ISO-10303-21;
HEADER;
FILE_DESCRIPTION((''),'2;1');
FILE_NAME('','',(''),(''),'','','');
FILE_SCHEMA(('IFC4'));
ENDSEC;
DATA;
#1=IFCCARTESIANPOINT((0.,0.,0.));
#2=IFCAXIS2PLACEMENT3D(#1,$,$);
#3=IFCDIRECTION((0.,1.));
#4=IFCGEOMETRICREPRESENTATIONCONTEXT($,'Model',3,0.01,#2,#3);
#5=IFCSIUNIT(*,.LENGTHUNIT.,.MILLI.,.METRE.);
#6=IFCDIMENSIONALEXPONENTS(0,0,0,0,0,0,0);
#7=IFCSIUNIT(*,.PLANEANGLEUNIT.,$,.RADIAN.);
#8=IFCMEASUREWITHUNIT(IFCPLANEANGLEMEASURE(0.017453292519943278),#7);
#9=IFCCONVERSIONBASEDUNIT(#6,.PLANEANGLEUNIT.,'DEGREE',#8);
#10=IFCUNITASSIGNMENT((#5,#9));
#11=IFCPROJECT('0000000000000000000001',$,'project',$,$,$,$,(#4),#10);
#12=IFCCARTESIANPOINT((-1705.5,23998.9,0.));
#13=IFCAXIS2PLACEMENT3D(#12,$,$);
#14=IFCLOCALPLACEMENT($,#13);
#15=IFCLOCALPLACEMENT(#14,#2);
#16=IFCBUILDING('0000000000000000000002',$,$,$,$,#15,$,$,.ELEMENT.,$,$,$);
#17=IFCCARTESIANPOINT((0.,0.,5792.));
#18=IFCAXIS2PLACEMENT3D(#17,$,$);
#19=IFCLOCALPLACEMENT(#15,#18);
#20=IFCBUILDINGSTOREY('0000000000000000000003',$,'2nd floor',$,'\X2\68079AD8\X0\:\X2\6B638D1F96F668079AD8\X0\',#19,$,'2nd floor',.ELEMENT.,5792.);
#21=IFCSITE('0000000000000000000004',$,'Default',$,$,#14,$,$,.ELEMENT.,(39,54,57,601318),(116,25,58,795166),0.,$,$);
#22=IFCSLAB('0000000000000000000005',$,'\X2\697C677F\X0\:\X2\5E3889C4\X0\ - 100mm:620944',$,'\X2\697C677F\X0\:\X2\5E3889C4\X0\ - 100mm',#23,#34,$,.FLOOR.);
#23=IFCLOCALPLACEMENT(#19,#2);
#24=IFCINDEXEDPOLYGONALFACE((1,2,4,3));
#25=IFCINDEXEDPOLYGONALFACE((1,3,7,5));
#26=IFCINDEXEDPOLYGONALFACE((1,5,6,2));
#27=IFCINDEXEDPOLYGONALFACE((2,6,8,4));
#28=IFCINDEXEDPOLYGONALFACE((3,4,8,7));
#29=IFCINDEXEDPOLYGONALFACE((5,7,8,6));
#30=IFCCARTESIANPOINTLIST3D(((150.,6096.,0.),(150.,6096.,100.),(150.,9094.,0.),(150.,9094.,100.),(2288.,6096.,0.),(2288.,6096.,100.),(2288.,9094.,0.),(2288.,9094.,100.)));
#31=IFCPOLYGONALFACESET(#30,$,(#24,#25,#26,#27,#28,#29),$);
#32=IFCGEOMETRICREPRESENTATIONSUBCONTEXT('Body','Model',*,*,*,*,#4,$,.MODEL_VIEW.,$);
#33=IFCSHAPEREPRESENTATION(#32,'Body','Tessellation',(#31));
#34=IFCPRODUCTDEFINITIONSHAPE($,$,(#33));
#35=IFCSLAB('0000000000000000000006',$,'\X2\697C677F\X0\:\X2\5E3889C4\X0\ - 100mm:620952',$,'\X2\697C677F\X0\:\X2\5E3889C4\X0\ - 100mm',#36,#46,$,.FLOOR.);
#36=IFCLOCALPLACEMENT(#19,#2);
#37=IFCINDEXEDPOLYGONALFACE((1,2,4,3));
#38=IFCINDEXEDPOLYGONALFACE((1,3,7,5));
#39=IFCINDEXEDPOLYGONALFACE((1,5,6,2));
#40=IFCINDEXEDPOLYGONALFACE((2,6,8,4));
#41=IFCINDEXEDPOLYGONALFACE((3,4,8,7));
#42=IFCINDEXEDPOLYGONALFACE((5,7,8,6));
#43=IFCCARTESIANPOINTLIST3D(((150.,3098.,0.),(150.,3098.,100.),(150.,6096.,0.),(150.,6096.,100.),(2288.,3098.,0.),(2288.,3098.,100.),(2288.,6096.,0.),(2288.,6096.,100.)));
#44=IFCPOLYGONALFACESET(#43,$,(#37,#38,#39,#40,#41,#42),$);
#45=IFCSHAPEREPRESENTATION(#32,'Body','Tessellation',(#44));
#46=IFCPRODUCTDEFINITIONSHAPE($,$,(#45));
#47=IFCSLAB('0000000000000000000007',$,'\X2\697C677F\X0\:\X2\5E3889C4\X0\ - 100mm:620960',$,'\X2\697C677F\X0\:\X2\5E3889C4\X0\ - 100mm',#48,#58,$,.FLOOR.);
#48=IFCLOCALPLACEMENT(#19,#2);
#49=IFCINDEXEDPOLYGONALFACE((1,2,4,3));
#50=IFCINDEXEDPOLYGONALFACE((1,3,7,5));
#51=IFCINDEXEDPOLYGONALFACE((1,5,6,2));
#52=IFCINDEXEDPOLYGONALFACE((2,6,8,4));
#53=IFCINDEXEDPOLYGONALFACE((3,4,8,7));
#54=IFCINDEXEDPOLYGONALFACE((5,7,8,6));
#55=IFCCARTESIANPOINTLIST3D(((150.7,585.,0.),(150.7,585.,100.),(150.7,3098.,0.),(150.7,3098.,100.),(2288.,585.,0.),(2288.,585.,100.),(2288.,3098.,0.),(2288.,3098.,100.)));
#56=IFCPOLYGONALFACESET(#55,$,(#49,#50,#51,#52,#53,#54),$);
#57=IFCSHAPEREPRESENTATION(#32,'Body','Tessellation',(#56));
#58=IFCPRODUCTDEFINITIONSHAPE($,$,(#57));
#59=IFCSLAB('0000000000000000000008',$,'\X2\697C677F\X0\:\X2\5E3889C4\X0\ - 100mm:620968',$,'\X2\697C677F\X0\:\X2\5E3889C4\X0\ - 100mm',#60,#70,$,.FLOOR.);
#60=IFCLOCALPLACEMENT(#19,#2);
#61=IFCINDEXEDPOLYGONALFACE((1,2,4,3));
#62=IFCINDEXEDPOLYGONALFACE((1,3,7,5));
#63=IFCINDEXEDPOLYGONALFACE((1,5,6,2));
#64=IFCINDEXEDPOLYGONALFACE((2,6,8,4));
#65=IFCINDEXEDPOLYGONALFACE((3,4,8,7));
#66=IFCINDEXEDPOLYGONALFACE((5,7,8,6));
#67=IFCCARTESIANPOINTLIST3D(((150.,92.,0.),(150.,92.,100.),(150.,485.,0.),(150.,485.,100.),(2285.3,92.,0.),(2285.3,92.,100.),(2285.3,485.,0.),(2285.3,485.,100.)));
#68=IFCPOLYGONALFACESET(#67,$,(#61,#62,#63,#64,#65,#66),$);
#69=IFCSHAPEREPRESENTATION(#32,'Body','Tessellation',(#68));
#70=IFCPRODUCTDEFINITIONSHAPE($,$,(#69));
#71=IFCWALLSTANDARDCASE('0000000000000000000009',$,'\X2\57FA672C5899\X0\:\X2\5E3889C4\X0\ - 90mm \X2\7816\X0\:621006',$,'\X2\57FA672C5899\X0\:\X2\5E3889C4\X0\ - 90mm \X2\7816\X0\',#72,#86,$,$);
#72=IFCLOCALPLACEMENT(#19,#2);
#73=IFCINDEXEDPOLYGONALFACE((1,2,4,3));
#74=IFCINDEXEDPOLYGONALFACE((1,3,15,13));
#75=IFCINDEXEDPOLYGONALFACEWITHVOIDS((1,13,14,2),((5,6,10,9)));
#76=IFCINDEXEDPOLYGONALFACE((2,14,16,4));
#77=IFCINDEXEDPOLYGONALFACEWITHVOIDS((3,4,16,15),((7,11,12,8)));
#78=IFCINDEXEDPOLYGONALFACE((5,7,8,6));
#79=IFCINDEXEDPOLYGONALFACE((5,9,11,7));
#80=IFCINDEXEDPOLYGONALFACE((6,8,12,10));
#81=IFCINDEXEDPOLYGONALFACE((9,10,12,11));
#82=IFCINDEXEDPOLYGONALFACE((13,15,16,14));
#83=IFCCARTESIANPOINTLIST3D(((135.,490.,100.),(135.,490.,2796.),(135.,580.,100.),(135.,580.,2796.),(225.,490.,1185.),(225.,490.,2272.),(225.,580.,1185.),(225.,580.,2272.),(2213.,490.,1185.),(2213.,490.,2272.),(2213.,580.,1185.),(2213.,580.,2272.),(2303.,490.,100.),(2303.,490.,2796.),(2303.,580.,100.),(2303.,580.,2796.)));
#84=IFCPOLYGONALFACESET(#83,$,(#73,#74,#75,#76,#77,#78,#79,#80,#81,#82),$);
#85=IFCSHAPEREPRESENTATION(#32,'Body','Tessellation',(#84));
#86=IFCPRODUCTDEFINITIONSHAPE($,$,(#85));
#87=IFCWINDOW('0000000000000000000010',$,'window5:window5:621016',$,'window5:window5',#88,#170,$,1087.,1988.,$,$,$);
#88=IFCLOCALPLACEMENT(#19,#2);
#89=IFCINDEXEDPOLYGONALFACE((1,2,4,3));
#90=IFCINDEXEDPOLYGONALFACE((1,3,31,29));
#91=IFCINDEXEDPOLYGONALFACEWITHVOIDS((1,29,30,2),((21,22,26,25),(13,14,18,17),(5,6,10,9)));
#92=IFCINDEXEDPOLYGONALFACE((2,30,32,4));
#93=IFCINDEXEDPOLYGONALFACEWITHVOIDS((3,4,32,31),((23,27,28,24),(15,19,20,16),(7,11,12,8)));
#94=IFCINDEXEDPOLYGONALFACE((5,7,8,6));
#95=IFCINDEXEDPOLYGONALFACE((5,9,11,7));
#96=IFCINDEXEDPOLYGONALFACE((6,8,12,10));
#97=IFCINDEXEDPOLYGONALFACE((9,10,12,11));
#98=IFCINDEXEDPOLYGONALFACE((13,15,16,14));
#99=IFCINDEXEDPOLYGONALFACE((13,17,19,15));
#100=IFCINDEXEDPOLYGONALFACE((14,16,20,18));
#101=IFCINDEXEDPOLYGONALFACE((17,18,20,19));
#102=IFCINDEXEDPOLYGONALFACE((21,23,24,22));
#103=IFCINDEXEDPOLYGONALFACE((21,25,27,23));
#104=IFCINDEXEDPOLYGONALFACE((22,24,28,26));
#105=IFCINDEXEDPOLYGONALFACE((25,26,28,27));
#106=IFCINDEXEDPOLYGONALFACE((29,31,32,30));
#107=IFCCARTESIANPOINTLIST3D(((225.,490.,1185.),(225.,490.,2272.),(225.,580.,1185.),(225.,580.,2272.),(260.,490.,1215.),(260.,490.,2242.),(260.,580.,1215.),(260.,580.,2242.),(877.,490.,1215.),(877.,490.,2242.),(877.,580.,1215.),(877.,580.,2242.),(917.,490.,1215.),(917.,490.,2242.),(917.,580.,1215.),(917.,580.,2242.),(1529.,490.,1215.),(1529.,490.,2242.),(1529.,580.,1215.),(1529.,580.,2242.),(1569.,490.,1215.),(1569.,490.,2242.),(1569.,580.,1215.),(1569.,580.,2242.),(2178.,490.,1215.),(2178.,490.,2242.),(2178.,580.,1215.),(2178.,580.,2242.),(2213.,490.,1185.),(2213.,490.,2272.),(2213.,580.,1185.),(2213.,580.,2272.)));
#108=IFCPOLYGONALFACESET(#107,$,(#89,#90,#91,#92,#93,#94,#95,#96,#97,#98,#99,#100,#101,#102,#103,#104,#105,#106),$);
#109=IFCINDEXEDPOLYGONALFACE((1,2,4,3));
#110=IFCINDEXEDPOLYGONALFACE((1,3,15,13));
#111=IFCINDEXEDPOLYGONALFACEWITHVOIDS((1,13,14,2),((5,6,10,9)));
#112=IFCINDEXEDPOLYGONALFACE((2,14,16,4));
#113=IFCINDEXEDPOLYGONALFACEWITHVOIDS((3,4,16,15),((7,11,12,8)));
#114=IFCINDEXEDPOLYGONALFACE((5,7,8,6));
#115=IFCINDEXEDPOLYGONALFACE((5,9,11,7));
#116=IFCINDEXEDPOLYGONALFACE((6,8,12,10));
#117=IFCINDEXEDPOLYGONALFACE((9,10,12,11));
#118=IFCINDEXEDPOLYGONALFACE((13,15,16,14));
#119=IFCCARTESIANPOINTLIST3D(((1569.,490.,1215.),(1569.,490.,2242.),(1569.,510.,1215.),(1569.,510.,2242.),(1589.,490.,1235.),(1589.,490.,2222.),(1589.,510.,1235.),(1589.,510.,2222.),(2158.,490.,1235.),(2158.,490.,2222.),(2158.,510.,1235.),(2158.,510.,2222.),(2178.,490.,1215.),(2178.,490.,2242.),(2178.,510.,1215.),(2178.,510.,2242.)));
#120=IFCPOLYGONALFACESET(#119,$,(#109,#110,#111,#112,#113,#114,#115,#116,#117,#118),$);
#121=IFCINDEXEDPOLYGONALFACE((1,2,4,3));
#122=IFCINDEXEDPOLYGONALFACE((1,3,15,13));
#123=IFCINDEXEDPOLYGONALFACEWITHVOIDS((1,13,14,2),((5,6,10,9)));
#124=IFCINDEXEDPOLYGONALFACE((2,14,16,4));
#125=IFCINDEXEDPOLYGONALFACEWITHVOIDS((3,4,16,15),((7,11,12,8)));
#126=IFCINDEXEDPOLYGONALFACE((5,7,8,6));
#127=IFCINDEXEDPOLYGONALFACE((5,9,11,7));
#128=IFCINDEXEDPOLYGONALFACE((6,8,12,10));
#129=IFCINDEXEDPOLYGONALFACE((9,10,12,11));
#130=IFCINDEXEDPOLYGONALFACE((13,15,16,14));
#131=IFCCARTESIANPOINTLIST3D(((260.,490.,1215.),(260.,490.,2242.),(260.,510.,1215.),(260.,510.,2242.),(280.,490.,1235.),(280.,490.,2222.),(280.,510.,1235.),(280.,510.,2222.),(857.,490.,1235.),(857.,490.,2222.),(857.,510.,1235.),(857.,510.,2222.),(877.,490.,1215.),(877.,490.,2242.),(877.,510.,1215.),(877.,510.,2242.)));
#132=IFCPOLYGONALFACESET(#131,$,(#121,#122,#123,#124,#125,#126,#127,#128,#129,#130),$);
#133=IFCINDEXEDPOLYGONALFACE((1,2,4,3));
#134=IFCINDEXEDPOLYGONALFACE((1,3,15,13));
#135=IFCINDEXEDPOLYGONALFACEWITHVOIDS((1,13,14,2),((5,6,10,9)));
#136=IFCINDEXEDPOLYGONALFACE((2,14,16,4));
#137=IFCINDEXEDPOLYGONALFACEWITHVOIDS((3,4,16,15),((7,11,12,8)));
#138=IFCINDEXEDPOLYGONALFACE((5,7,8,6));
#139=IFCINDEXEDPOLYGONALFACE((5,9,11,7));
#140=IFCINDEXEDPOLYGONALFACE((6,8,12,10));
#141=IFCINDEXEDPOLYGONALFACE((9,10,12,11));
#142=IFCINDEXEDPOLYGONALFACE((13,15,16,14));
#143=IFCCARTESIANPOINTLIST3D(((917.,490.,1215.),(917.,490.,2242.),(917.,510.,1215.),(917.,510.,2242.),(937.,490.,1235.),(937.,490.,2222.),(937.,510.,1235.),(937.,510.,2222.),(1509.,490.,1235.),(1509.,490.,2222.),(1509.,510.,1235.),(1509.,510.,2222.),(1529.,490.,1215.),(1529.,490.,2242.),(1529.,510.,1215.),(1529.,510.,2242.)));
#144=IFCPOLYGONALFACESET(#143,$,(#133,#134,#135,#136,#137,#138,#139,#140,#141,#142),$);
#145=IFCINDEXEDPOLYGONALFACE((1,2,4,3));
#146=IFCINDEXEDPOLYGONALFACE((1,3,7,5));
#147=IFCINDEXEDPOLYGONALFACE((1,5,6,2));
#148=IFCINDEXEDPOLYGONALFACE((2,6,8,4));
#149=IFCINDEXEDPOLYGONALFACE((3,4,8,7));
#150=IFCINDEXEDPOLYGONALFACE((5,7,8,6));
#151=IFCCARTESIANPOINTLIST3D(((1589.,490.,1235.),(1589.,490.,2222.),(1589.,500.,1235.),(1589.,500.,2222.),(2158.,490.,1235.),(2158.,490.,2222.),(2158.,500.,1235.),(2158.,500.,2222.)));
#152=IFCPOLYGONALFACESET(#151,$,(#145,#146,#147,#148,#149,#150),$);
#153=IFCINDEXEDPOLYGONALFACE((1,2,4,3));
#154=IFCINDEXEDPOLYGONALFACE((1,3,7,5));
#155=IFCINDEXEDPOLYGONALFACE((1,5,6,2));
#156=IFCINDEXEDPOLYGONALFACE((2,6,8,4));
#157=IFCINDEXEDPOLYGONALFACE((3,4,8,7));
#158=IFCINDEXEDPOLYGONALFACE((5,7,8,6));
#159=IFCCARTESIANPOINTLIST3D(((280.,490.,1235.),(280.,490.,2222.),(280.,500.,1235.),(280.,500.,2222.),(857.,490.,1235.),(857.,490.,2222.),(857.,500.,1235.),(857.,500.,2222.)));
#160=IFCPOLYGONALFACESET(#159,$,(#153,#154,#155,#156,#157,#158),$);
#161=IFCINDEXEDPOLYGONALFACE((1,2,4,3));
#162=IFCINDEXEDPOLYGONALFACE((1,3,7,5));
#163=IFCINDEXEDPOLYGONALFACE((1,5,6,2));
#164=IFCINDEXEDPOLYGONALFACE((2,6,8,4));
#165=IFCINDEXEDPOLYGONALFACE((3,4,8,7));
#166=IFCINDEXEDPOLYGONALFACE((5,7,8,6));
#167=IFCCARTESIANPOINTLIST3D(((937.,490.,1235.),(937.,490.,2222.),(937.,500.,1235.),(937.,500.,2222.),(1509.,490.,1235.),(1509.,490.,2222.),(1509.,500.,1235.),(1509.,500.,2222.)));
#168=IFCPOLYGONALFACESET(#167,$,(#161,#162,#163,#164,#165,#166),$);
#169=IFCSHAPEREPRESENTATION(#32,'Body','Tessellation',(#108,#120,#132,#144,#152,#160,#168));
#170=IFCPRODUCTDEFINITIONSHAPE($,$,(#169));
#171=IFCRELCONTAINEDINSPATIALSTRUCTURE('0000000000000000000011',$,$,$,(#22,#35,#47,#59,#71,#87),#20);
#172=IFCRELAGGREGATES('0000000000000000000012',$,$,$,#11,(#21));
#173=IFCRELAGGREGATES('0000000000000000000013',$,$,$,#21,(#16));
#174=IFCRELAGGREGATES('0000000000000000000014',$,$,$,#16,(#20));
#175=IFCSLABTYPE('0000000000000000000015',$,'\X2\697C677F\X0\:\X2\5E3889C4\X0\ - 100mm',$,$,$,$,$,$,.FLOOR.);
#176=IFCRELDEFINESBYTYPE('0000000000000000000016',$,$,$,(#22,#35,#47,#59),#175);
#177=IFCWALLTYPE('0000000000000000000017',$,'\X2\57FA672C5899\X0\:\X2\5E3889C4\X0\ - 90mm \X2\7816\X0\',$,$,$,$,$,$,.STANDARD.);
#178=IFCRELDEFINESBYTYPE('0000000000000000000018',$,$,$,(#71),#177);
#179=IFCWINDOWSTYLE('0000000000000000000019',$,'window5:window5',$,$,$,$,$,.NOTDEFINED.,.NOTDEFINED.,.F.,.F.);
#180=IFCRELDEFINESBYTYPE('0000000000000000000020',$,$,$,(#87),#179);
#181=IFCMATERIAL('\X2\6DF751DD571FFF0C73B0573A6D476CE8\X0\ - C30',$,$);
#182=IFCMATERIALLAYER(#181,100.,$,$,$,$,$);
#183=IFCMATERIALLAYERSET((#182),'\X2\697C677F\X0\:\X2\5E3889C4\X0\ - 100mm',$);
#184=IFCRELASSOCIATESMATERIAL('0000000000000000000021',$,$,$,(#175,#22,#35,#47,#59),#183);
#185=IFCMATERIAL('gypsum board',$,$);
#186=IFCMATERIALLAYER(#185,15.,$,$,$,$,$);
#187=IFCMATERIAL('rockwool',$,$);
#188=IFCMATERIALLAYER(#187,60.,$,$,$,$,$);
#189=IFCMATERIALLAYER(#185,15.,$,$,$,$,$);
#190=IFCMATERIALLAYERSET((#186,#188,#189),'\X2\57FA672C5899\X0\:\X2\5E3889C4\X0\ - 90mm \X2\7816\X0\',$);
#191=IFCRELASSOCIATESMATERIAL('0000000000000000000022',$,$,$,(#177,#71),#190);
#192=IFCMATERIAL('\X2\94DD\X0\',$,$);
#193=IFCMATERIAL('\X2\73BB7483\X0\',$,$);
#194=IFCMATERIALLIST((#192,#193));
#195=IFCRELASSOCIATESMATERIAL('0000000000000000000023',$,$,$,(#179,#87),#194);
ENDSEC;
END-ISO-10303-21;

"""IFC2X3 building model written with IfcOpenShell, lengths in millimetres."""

from ifc_helpers import new_model, entity, si_unit, converted_unit, direction, frame, frame_2d, origin, origin_2d_with_axis, place, context, subcontext, project, spatial, polyline, rectangle, outline, extrude, source, transform, mapped, material, material_list, layer, layer_set, layer_usage, type_object, type_shapes, element, fill, save


model = new_model("IFC2X3")

# Units and contexts
model_context = context("Model", 3, precision=0.01, world=origin(), true_north=direction((0.0, 1.0)))
body_context = subcontext(model_context, "Body", "Model", "MODEL_VIEW")
ifc_project = project(units=[si_unit("LENGTHUNIT", "METRE", prefix="MILLI"), converted_unit("PLANEANGLEUNIT", "DEGREE", entity("IfcPlaneAngleMeasure", 0.017453292519943278), si_unit("PLANEANGLEUNIT", "RADIAN"), dimensions=[0, 0, 0, 0, 0, 0, 0])], contexts=[model_context])

# Site, building, storey
site_placement = place(None, frame((-1705.5, 23998.9, 0.0)))
site = spatial("IfcSite", under=ifc_project, at=site_placement, Name="Default", CompositionType="ELEMENT", RefLatitude=(39, 54, 57, 601318), RefLongitude=(116, 25, 58, 795166), RefElevation=0.0)
building_placement = place(site_placement, origin())
building = spatial("IfcBuilding", under=site, at=building_placement, CompositionType="ELEMENT")
storey_placement = place(building_placement, frame((0.0, 0.0, 5792.0)))
storey = spatial("IfcBuildingStorey", under=building, at=storey_placement, Name="2nd floor", ObjectType="标高:正负零标高", LongName="2nd floor", CompositionType="ELEMENT", Elevation=5792.0)

# Slabs
ifc_material_1 = material(Name="混凝土，现场浇注 - C30")
ifc_layer_1 = layer(ifc_material_1, 100.0)
ifc_layer_set_1 = layer_set([ifc_layer_1], Name="楼板:常规 - 100mm")
slab_type = type_object("IfcSlabType", Name="楼板:常规 - 100mm", PredefinedType="FLOOR", material=ifc_layer_set_1)
ifc_layer_usage_1 = layer_usage(ifc_layer_set_1, "AXIS3", "POSITIVE", 0.0)
slab_1_placement = place(storey_placement, origin())
element("IfcSlab", 1, at=slab_1_placement, inside=storey, type_object=slab_type, material=ifc_layer_usage_1, Name="楼板:常规 - 100mm:620944", ObjectType="楼板:常规 - 100mm", PredefinedType="FLOOR", context=body_context, shape_type="SweptSolid", body=[
    extrude(rectangle(XDim=2998.0, YDim=2138.0, at=origin_2d_with_axis()), frame((1219.0, 7595.0, 100.0), z_axis=(0.0, 0.0, -1.0), x_axis=(0.0, 1.0, 0.0)), (0.0, 0.0, 1.0), 100.0),
])
ifc_layer_usage_2 = layer_usage(ifc_layer_set_1, "AXIS3", "POSITIVE", 0.0)
slab_2_placement = place(storey_placement, origin())
element("IfcSlab", 2, at=slab_2_placement, inside=storey, type_object=slab_type, material=ifc_layer_usage_2, Name="楼板:常规 - 100mm:620952", ObjectType="楼板:常规 - 100mm", PredefinedType="FLOOR", context=body_context, shape_type="SweptSolid", body=[
    extrude(rectangle(XDim=2998.0, YDim=2138.0, at=frame_2d((0.0, 0.0), x_axis=(1.0, 0.0))), frame((1219.0, 4597.0, 100.0), z_axis=(0.0, 0.0, -1.0), x_axis=(0.0, 1.0, 0.0)), (0.0, 0.0, 1.0), 100.0),
])
ifc_layer_usage_3 = layer_usage(ifc_layer_set_1, "AXIS3", "POSITIVE", 0.0)
slab_3_placement = place(storey_placement, origin())
element("IfcSlab", 3, at=slab_3_placement, inside=storey, type_object=slab_type, material=ifc_layer_usage_3, Name="楼板:常规 - 100mm:620960", ObjectType="楼板:常规 - 100mm", PredefinedType="FLOOR", context=body_context, shape_type="SweptSolid", body=[
    extrude(rectangle(XDim=2513.0, YDim=2137.3, at=origin_2d_with_axis()), frame((1219.3, 1841.5, 100.0), z_axis=(0.0, 0.0, -1.0), x_axis=(0.0, 1.0, 0.0)), (0.0, 0.0, 1.0), 100.0),
])
ifc_layer_usage_4 = layer_usage(ifc_layer_set_1, "AXIS3", "POSITIVE", 0.0)
slab_4_placement = place(storey_placement, origin())
element("IfcSlab", 4, at=slab_4_placement, inside=storey, type_object=slab_type, material=ifc_layer_usage_4, Name="楼板:常规 - 100mm:620968", ObjectType="楼板:常规 - 100mm", PredefinedType="FLOOR", context=body_context, shape_type="SweptSolid", body=[
    extrude(rectangle(XDim=393.0, YDim=2135.3, at=frame_2d((0.0, 0.0), x_axis=(1.0, 0.0))), frame((1217.7, 288.5, 100.0), z_axis=(0.0, 0.0, -1.0), x_axis=(0.0, 1.0, 0.0)), (0.0, 0.0, 1.0), 100.0),
])

# Wall, opening, window
ifc_material_2 = material(Name="gypsum board")
ifc_layer_2 = layer(ifc_material_2, 15.0)
ifc_material_3 = material(Name="rockwool")
ifc_layer_3 = layer(ifc_material_3, 60.0)
ifc_layer_4 = layer(ifc_material_2, 15.0)
ifc_layer_set_2 = layer_set([ifc_layer_2, ifc_layer_3, ifc_layer_4], Name="基本墙:常规 - 90mm 砖")
ifc_layer_usage_5 = layer_usage(ifc_layer_set_2, "AXIS2", "NEGATIVE", 45.0)
wall_type = type_object("IfcWallType", Name="基本墙:常规 - 90mm 砖", PredefinedType="STANDARD", material=ifc_layer_set_2)
wall_placement = place(storey_placement, frame((2303.0, 535.0, 100.0), z_axis=(0.0, 0.0, 1.0), x_axis=(-1.0, 0.0, 0.0)))
wall = element("IfcWallStandardCase", 5, at=wall_placement, inside=storey, type_object=wall_type, material=ifc_layer_usage_5, Name="基本墙:常规 - 90mm 砖:621006", ObjectType="基本墙:常规 - 90mm 砖", context=body_context, shape_type="SweptSolid", body=[
    extrude(rectangle(XDim=2168.0, YDim=90.0, at=frame_2d((1084.0, 0.0), x_axis=(-1.0, 0.0))), origin(), (0.0, 0.0, 1.0), 2696.0),
])
opening_1_placement = place(wall_placement, frame((90.0, -45.0, 1085.0)))
opening_1 = element("IfcOpeningElement", 6, at=opening_1_placement, cuts=wall, ObjectType="Opening", context=body_context, shape_type="SweptSolid", body=[
    extrude(rectangle(XDim=1087.0, YDim=1988.0, at=frame_2d((543.5, 994.0), x_axis=(1.0, 0.0))), frame((0.0, 0.0, 0.0), z_axis=(0.0, 1.0, 0.0), x_axis=(0.0, 0.0, 1.0)), (0.0, 0.0, 1.0), 90.0),
])
ifc_material_4 = material(Name="铝")
ifc_material_5 = material(Name="玻璃")
ifc_material_list = material_list([ifc_material_4, ifc_material_5])
window_style = type_object("IfcWindowStyle", Name="window5:window5", ConstructionType="NOTDEFINED", OperationType="NOTDEFINED", ParameterTakesPrecedence=False, Sizeable=False, material=ifc_material_list)
shared_shape = source(origin(), body_context, "Body", "SweptSolid", [
    extrude(outline(polyline([(-994.0, -543.5), (994.0, -543.5), (994.0, 543.5), (-994.0, 543.5), (-994.0, -543.5)]), holes=[polyline([(-959.0, 513.5), (-342.0, 513.5), (-342.0, -513.5), (-959.0, -513.5), (-959.0, 513.5)]), polyline([(-302.0, 513.5), (310.0, 513.5), (310.0, -513.5), (-302.0, -513.5), (-302.0, 513.5)]), polyline([(350.0, 513.5), (959.0, 513.5), (959.0, -513.5), (350.0, -513.5), (350.0, 513.5)])]), frame((994.0, 0.0, 543.5), z_axis=(0.0, 1.0, 0.0), x_axis=(-1.0, 0.0, 0.0)), (0.0, 0.0, 1.0), 90.0),
    extrude(outline(polyline([(-304.5, -513.5), (304.5, -513.5), (304.5, 513.5), (-304.5, 513.5), (-304.5, -513.5)]), holes=[polyline([(-284.5, -493.5), (-284.5, 493.5), (284.5, 493.5), (284.5, -493.5), (-284.5, -493.5)])]), frame((339.5, 70.0, 543.5), z_axis=(0.0, 1.0, 0.0), x_axis=(1.0, 0.0, 0.0)), (0.0, 0.0, 1.0), 20.0),
    extrude(outline(polyline([(-308.5, -513.5), (308.5, -513.5), (308.5, 513.5), (-308.5, 513.5), (-308.5, -513.5)]), holes=[polyline([(-288.5, -493.5), (-288.5, 493.5), (288.5, 493.5), (288.5, -493.5), (-288.5, -493.5)])]), frame((1644.5, 70.0, 543.5), z_axis=(0.0, 1.0, 0.0), x_axis=(1.0, 0.0, 0.0)), (0.0, 0.0, 1.0), 20.0),
    extrude(outline(polyline([(-306.0, -513.5), (306.0, -513.5), (306.0, 513.5), (-306.0, 513.5), (-306.0, -513.5)]), holes=[polyline([(-286.0, -493.5), (-286.0, 493.5), (286.0, 493.5), (286.0, -493.5), (-286.0, -493.5)])]), frame((990.0, 70.0, 543.5), z_axis=(0.0, 1.0, 0.0), x_axis=(1.0, 0.0, 0.0)), (0.0, 0.0, 1.0), 20.0),
    extrude(rectangle(XDim=10.0, YDim=569.0, at=frame_2d((0.0, 0.0), x_axis=(1.0, 0.0))), frame((339.5, 85.0, 50.0), z_axis=(0.0, 0.0, 1.0), x_axis=(0.0, 1.0, 0.0)), (0.0, 0.0, 1.0), 987.0),
    extrude(rectangle(XDim=10.0, YDim=577.0, at=frame_2d((0.0, 0.0), x_axis=(1.0, 0.0))), frame((1644.5, 85.0, 50.0), z_axis=(0.0, 0.0, 1.0), x_axis=(0.0, 1.0, 0.0)), (0.0, 0.0, 1.0), 987.0),
    extrude(rectangle(XDim=10.0, YDim=572.0, at=frame_2d((0.0, 0.0), x_axis=(1.0, 0.0))), frame((990.0, 85.0, 50.0), z_axis=(0.0, 0.0, 1.0), x_axis=(0.0, 1.0, 0.0)), (0.0, 0.0, 1.0), 987.0),
])
type_shapes(window_style, [shared_shape])
window_placement = place(opening_1_placement, origin())
window = element("IfcWindow", 7, at=window_placement, inside=storey, type_object=window_style, material=ifc_material_list, Name="window5:window5:621016", ObjectType="window5:window5", OverallHeight=1087.0, OverallWidth=1988.0, context=body_context, shape_type="MappedRepresentation", body=[
    mapped(shared_shape, transform((0.0, 0.0, 0.0), scale=1.0)),
])
fill(opening_1, window)

save(model, "model.ifc")
